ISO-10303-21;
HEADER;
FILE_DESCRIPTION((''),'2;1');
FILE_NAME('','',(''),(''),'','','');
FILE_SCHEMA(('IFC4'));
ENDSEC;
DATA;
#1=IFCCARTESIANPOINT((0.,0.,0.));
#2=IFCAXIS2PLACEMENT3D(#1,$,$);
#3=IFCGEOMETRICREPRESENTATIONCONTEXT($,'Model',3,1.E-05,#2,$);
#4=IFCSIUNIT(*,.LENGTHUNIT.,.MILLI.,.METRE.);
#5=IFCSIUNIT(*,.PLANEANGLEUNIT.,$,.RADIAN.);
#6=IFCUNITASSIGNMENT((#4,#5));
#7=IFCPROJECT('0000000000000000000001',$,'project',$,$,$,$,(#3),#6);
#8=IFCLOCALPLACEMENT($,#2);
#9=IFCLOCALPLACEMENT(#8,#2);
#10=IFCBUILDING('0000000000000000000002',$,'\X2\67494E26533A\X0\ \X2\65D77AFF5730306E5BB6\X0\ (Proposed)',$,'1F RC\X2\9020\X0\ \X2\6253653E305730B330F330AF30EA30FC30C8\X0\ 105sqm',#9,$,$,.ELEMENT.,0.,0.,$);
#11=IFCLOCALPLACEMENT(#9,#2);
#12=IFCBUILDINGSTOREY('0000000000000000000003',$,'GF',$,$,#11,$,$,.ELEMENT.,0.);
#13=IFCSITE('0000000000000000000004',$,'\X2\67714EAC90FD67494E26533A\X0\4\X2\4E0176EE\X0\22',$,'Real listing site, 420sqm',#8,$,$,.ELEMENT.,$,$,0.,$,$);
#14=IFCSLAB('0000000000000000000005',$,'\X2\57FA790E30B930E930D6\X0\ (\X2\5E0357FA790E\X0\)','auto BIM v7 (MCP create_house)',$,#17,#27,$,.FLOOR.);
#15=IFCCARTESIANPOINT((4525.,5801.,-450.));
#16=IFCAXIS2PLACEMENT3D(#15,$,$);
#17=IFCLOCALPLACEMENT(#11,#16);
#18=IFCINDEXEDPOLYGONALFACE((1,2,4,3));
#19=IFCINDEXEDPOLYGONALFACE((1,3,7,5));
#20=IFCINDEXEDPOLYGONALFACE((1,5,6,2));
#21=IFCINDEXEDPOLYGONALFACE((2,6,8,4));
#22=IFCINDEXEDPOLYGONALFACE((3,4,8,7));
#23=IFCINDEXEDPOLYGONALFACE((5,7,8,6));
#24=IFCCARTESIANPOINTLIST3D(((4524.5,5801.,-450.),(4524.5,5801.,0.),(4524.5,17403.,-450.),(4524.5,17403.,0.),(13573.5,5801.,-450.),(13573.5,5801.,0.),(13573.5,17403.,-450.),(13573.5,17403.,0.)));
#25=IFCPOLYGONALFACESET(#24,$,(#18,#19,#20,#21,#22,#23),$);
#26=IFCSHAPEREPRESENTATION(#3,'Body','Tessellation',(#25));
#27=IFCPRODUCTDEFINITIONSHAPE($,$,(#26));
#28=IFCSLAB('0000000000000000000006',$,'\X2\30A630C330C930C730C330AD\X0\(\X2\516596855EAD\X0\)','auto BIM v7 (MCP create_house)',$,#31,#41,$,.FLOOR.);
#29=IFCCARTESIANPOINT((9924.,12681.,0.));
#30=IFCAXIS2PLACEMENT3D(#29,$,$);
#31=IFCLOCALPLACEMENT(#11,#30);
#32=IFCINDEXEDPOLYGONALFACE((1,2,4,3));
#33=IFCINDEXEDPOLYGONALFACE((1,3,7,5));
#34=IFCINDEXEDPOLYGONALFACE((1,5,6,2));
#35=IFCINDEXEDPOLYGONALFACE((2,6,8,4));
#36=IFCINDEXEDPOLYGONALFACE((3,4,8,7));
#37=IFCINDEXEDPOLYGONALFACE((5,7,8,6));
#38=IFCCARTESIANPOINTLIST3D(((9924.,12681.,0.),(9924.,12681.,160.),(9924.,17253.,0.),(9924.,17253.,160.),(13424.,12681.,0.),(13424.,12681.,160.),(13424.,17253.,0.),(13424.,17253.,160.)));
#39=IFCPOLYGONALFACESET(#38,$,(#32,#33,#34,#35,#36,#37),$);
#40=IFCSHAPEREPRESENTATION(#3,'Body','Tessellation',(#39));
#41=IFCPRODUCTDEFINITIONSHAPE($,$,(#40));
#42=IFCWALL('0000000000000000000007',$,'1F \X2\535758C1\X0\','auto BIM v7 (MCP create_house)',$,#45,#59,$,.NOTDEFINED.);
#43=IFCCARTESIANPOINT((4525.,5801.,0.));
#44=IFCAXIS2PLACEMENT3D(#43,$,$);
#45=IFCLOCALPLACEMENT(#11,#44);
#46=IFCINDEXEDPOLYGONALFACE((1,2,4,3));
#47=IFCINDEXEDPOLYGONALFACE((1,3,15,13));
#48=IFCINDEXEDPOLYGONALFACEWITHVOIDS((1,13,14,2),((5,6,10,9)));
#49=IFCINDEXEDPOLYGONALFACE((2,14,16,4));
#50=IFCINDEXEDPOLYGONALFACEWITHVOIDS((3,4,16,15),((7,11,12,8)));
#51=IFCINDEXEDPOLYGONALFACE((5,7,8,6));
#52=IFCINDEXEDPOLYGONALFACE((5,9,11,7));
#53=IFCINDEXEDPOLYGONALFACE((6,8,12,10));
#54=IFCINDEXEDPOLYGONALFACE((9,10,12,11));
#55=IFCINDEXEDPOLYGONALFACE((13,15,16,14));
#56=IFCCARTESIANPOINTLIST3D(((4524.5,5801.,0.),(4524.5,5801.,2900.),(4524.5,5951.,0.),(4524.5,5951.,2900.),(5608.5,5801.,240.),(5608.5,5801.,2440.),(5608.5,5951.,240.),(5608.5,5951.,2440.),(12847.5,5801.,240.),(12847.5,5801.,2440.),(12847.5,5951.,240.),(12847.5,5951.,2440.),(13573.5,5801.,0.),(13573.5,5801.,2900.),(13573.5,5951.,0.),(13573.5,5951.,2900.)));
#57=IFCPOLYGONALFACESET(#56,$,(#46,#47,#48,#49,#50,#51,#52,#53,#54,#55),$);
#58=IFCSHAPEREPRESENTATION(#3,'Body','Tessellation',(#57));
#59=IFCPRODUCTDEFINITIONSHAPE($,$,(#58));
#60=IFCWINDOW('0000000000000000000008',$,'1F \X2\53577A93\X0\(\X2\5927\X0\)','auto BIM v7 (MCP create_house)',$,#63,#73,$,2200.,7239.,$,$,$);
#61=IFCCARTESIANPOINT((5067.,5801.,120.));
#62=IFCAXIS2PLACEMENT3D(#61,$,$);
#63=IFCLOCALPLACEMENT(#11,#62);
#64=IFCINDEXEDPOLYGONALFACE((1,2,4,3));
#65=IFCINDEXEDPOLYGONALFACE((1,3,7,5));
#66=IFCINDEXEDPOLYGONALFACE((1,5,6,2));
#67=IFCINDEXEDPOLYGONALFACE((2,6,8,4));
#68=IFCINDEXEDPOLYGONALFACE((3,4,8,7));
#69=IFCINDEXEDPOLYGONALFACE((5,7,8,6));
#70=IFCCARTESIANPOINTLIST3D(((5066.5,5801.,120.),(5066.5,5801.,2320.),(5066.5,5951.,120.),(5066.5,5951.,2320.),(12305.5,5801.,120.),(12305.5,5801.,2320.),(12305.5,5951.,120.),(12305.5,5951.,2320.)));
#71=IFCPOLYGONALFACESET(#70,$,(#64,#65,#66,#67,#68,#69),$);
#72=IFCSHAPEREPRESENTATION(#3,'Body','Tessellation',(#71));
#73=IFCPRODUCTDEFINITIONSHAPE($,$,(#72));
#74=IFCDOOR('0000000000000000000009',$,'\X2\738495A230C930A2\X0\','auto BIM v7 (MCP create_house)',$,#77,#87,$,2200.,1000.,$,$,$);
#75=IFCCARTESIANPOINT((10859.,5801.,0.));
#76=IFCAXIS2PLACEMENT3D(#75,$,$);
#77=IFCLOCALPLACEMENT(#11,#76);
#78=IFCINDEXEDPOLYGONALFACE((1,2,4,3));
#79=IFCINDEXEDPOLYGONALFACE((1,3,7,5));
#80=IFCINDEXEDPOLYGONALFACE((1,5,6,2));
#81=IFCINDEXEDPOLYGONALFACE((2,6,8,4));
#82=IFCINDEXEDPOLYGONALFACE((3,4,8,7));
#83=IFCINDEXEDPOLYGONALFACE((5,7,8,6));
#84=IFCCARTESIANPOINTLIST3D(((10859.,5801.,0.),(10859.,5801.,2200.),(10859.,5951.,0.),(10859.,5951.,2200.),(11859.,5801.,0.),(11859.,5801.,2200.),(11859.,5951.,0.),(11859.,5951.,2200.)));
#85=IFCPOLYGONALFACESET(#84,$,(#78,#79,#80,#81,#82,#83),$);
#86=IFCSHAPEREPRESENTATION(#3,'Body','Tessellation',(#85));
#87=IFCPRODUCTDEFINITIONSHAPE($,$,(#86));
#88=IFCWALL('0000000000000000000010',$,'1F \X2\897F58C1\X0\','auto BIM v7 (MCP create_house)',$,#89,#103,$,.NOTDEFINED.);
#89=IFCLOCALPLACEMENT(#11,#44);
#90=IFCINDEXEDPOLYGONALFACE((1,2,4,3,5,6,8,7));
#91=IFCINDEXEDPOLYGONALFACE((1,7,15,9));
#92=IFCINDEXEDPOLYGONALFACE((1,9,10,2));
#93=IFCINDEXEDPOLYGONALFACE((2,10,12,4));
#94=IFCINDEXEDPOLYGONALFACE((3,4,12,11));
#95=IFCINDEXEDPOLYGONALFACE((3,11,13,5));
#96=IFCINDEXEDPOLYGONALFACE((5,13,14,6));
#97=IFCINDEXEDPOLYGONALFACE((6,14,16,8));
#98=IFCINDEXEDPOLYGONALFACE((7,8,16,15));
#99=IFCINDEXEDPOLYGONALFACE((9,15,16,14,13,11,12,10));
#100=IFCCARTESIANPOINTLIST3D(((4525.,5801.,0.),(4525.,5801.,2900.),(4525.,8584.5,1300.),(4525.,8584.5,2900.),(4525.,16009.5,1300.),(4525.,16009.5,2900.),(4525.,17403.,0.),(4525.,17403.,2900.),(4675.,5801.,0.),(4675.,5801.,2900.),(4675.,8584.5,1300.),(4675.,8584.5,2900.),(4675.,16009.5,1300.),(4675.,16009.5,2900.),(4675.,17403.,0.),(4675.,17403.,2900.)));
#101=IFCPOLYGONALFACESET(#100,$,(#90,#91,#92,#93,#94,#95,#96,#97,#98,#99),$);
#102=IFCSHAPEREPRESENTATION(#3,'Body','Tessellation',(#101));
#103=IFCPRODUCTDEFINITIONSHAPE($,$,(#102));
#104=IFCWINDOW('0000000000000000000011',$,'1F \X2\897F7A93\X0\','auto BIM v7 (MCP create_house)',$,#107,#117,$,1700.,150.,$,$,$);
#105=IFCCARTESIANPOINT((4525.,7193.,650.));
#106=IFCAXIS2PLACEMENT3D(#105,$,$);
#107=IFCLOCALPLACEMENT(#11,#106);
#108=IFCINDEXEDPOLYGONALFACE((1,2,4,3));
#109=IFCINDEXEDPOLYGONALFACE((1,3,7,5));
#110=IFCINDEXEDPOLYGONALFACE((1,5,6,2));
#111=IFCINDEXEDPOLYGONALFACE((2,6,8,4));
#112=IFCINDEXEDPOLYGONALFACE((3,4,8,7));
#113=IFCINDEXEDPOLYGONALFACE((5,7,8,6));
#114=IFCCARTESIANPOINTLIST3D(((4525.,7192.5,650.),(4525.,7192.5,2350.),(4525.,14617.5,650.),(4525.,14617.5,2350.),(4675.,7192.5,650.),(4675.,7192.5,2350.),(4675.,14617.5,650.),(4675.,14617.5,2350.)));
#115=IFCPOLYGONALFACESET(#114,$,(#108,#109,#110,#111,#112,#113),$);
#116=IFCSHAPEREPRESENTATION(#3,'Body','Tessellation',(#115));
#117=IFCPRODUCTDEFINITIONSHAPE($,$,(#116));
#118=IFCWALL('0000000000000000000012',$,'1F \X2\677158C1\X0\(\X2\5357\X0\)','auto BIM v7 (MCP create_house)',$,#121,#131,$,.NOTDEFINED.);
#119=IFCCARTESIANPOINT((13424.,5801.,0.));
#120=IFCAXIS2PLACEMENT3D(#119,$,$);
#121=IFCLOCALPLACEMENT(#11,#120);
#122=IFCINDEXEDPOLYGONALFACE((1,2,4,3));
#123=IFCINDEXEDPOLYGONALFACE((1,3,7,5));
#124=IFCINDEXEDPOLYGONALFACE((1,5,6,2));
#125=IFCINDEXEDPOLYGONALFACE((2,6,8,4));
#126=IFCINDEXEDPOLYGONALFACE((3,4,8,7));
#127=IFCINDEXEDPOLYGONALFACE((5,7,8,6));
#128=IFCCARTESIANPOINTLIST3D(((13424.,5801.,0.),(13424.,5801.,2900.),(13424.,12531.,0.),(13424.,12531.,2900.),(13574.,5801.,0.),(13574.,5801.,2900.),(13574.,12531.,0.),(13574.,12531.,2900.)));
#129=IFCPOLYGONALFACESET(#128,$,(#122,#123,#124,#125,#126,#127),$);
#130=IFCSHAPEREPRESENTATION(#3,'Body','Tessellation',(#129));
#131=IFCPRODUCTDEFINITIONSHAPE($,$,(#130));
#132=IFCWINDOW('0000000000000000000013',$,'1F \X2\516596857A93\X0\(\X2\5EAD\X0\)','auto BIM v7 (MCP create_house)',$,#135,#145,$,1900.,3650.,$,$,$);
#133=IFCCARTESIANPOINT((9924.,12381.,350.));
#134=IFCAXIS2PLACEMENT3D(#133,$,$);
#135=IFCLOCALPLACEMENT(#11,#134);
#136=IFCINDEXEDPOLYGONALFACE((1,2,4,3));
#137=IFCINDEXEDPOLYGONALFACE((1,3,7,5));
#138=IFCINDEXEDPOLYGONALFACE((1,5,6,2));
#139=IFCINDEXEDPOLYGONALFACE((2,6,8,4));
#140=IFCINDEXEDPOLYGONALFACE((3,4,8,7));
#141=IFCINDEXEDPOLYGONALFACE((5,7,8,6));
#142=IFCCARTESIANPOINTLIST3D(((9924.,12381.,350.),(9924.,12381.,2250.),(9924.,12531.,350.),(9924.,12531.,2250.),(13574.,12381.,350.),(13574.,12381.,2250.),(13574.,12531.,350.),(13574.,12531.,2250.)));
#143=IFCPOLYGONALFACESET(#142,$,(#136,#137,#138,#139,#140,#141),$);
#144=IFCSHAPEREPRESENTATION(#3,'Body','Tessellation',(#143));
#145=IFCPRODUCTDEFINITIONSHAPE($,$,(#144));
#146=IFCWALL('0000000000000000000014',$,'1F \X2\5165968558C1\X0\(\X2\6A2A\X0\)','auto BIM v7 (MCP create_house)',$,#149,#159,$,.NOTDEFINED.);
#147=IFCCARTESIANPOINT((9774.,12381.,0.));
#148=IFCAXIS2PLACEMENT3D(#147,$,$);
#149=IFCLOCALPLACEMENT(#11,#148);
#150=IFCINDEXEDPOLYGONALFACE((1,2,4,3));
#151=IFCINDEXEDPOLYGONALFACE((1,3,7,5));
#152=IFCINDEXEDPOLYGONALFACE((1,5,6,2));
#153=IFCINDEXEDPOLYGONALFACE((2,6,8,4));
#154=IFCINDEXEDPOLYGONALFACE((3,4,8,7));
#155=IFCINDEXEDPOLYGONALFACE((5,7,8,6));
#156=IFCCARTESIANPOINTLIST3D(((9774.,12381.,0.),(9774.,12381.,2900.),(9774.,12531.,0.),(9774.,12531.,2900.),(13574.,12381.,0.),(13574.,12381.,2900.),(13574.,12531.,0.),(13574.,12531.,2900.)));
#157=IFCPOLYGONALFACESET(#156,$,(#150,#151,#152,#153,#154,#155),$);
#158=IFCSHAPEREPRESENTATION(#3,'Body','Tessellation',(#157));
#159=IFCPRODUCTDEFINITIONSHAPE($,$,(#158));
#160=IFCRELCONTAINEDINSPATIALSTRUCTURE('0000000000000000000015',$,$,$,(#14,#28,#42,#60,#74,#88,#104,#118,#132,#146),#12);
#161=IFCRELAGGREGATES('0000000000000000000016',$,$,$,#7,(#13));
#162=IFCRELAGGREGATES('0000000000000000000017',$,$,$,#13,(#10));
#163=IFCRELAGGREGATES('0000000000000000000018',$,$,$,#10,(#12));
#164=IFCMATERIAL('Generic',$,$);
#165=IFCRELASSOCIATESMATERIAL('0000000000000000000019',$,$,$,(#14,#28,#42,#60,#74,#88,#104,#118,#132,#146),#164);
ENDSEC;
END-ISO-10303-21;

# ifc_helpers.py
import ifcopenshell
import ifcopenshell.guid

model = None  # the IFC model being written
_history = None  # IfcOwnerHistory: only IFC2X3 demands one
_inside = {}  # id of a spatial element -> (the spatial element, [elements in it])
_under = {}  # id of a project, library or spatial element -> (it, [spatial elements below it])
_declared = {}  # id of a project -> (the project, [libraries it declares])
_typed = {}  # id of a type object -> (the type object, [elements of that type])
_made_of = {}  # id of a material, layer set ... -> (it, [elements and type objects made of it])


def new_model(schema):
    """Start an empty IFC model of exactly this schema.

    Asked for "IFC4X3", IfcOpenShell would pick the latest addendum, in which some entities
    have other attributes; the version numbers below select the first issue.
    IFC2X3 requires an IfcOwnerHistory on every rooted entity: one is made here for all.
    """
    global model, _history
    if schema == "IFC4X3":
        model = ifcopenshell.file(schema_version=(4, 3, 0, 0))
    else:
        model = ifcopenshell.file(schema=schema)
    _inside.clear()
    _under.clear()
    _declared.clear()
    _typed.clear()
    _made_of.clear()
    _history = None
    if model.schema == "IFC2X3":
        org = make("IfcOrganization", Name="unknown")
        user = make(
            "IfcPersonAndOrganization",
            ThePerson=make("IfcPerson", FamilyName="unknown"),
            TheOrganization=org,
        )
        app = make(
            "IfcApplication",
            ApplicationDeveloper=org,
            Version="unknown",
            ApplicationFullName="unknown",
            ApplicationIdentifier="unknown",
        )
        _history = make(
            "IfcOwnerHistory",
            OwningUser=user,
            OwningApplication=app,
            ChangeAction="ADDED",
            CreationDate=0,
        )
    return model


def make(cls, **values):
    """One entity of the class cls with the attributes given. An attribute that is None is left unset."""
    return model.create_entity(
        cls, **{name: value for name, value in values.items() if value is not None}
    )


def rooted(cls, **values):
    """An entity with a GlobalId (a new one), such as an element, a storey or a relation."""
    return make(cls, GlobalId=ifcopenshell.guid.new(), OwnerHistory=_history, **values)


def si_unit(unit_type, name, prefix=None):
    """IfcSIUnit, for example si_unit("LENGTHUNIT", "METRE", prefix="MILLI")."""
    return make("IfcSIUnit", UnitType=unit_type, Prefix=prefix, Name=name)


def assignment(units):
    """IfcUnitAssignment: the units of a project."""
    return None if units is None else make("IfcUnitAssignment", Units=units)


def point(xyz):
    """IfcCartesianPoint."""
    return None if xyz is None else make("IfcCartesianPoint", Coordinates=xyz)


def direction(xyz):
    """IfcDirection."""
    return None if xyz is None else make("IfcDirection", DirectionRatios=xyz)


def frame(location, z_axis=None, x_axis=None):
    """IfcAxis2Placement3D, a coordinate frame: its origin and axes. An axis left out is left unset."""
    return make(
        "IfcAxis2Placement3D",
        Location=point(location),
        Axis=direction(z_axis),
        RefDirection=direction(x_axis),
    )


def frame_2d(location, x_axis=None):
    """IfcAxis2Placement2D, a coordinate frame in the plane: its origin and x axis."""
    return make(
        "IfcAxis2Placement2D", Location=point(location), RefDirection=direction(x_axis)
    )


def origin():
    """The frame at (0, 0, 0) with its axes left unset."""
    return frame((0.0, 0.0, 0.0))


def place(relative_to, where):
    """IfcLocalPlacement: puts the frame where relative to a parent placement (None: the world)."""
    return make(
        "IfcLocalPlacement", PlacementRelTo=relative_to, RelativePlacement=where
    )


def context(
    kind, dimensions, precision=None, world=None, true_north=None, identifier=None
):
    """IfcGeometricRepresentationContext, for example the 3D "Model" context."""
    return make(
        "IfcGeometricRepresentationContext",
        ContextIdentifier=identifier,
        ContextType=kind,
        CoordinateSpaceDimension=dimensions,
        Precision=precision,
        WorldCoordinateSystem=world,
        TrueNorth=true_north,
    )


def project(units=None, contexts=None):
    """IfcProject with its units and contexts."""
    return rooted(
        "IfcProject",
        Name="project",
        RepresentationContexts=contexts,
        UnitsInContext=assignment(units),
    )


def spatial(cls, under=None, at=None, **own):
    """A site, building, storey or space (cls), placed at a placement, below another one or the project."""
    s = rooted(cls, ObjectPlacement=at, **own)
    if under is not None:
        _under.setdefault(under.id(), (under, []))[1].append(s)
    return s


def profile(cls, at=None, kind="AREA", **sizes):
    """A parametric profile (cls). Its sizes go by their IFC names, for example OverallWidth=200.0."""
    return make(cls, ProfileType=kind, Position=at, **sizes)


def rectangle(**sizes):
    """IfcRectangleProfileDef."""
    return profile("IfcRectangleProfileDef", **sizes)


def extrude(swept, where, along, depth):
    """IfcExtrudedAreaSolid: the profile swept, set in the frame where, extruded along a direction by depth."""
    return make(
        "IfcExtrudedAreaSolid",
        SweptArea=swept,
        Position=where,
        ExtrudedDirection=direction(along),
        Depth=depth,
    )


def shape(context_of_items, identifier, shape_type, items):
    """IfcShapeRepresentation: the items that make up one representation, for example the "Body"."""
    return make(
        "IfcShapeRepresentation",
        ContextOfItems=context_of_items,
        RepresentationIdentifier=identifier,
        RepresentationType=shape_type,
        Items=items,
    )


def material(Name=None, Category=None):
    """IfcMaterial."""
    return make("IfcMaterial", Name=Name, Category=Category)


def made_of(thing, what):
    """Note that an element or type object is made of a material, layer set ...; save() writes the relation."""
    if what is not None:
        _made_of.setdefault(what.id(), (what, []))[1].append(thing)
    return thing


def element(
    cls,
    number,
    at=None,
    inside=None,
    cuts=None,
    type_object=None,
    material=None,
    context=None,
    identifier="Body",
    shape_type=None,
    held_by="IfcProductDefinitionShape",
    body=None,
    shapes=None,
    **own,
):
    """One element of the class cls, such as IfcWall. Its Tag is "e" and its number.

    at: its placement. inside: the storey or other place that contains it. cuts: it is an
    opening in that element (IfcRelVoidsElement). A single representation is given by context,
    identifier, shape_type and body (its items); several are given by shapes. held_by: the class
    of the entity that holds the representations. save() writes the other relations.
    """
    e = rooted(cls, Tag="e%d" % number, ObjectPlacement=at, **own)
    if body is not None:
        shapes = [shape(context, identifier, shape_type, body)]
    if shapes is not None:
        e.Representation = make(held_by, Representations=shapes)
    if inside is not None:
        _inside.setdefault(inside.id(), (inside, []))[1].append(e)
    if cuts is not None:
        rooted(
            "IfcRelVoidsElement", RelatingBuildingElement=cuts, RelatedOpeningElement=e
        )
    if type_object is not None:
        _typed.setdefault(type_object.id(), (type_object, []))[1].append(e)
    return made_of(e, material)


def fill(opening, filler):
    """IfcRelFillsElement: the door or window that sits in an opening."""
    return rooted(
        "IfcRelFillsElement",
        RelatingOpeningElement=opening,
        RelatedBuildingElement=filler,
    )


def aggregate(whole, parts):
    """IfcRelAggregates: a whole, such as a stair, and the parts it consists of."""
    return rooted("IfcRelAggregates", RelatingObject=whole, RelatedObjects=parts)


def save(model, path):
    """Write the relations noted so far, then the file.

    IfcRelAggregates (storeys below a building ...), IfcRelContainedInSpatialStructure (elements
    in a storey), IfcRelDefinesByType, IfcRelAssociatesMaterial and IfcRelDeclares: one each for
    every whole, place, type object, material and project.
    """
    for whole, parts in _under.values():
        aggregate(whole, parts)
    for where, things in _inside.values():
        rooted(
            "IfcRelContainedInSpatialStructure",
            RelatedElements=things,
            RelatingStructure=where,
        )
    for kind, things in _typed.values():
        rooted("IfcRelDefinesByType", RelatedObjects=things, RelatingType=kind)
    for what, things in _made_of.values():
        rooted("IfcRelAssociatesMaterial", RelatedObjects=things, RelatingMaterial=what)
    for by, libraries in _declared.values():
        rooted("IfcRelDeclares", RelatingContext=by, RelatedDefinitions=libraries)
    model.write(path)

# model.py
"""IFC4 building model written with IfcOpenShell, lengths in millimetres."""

from ifc_helpers import new_model, si_unit, frame, frame_2d, origin, place, context, project, spatial, rectangle, extrude, material, element, fill, save


model = new_model("IFC4")

# Units and contexts
model_context = context("Model", 3, precision=1e-05, world=origin())
ifc_project = project(units=[si_unit("LENGTHUNIT", "METRE", prefix="MILLI"), si_unit("PLANEANGLEUNIT", "RADIAN")], contexts=[model_context])

# Site, building, storey
site_placement = place(None, origin())
site = spatial("IfcSite", under=ifc_project, at=site_placement, Name="東京都杉並区4丁目22", ObjectType="Real listing site, 420sqm", CompositionType="ELEMENT", RefElevation=0.0)
building_placement = place(site_placement, origin())
building = spatial("IfcBuilding", under=site, at=building_placement, Name="杉並区 旗竿地の家 (Proposed)", ObjectType="1F RC造 打放しコンクリート 105sqm", CompositionType="ELEMENT", ElevationOfRefHeight=0.0, ElevationOfTerrain=0.0)
storey_placement = place(building_placement, origin())
storey = spatial("IfcBuildingStorey", under=building, at=storey_placement, Name="GF", CompositionType="ELEMENT", Elevation=0.0)

# Slabs
ifc_material = material(Name="Generic")
slab_1_placement = place(storey_placement, frame((4525.0, 5801.0, -450.0)))
element("IfcSlab", 1, at=slab_1_placement, inside=storey, material=ifc_material, Name="基礎スラブ (布基礎)", Description="auto BIM v7 (MCP create_house)", PredefinedType="FLOOR", context=model_context, shape_type="SweptSolid", body=[
    extrude(rectangle(XDim=9049.0, YDim=11602.0, at=frame_2d((4524.0, 5801.0))), frame((4525.0, 5801.0, -450.0)), (0.0, 0.0, 1.0), 450.0),
])
slab_2_placement = place(storey_placement, frame((9924.0, 12681.0, 0.0)))
element("IfcSlab", 2, at=slab_2_placement, inside=storey, material=ifc_material, Name="ウッドデッキ(入隅庭)", Description="auto BIM v7 (MCP create_house)", PredefinedType="FLOOR", context=model_context, shape_type="SweptSolid", body=[
    extrude(rectangle(XDim=3500.0, YDim=4572.0, at=frame_2d((1750.0, 2286.0))), frame((9924.0, 12681.0, 0.0)), (0.0, 0.0, 1.0), 160.0),
])

# Wall, openings, window, door
wall_1_placement = place(storey_placement, frame((4525.0, 5801.0, 0.0)))
wall_1 = element("IfcWall", 3, at=wall_1_placement, inside=storey, material=ifc_material, Name="1F 南壁", Description="auto BIM v7 (MCP create_house)", PredefinedType="NOTDEFINED", context=model_context, shape_type="SweptSolid", body=[
    extrude(rectangle(XDim=9049.0, YDim=150.0, at=frame_2d((4524.0, 75.0))), frame((4525.0, 5801.0, 0.0)), (0.0, 0.0, 1.0), 2900.0),
])
opening_1_placement = place(storey_placement, frame((5067.0, 5801.0, 120.0)))
opening_1 = element("IfcOpeningElement", 4, at=opening_1_placement, cuts=wall_1, PredefinedType="NOTDEFINED", context=model_context, shape_type="SweptSolid", body=[
    extrude(rectangle(XDim=7239.0, YDim=150.0, at=frame_2d((3619.0, 75.0))), frame((5067.0, 5801.0, 120.0)), (0.0, 0.0, 1.0), 2200.0),
])
opening_2_placement = place(storey_placement, frame((10859.0, 5801.0, 0.0)))
opening_2 = element("IfcOpeningElement", 5, at=opening_2_placement, cuts=wall_1, PredefinedType="NOTDEFINED", context=model_context, shape_type="SweptSolid", body=[
    extrude(rectangle(XDim=1000.0, YDim=150.0, at=frame_2d((500.0, 75.0))), frame((10859.0, 5801.0, 0.0)), (0.0, 0.0, 1.0), 2200.0),
])
window_1_placement = place(storey_placement, frame((5067.0, 5801.0, 120.0)))
window_1 = element("IfcWindow", 6, at=window_1_placement, inside=storey, material=ifc_material, Name="1F 南窓(大)", Description="auto BIM v7 (MCP create_house)", OverallHeight=2200.0, OverallWidth=7239.0, context=model_context, shape_type="SweptSolid", body=[
    extrude(rectangle(XDim=7239.0, YDim=150.0, at=frame_2d((3619.0, 75.0))), frame((5067.0, 5801.0, 120.0)), (0.0, 0.0, 1.0), 2200.0),
])
fill(opening_1, window_1)
door_placement = place(storey_placement, frame((10859.0, 5801.0, 0.0)))
door = element("IfcDoor", 7, at=door_placement, inside=storey, material=ifc_material, Name="玄関ドア", Description="auto BIM v7 (MCP create_house)", OverallHeight=2200.0, OverallWidth=1000.0, context=model_context, shape_type="SweptSolid", body=[
    extrude(rectangle(XDim=1000.0, YDim=150.0, at=frame_2d((500.0, 75.0))), frame((10859.0, 5801.0, 0.0)), (0.0, 0.0, 1.0), 2200.0),
])
fill(opening_2, door)

# Wall, opening, window
wall_2_placement = place(storey_placement, frame((4525.0, 5801.0, 0.0)))
wall_2 = element("IfcWall", 8, at=wall_2_placement, inside=storey, material=ifc_material, Name="1F 西壁", Description="auto BIM v7 (MCP create_house)", PredefinedType="NOTDEFINED", context=model_context, shape_type="SweptSolid", body=[
    extrude(rectangle(XDim=150.0, YDim=11602.0, at=frame_2d((75.0, 5801.0))), frame((4525.0, 5801.0, 0.0)), (0.0, 0.0, 1.0), 2900.0),
])
opening_3_placement = place(storey_placement, frame((4525.0, 7193.0, 650.0)))
opening_3 = element("IfcOpeningElement", 9, at=opening_3_placement, cuts=wall_2, PredefinedType="NOTDEFINED", context=model_context, shape_type="SweptSolid", body=[
    extrude(rectangle(XDim=150.0, YDim=7425.0, at=frame_2d((75.0, 3712.0))), frame((4525.0, 7193.0, 650.0)), (0.0, 0.0, 1.0), 1700.0),
])
window_2_placement = place(storey_placement, frame((4525.0, 7193.0, 650.0)))
window_2 = element("IfcWindow", 10, at=window_2_placement, inside=storey, material=ifc_material, Name="1F 西窓", Description="auto BIM v7 (MCP create_house)", OverallHeight=1700.0, OverallWidth=150.0, context=model_context, shape_type="SweptSolid", body=[
    extrude(rectangle(XDim=150.0, YDim=7425.0, at=frame_2d((75.0, 3712.0))), frame((4525.0, 7193.0, 650.0)), (0.0, 0.0, 1.0), 1700.0),
])
fill(opening_3, window_2)

# Wall, opening, window
wall_3_placement = place(storey_placement, frame((13424.0, 5801.0, 0.0)))
wall_3 = element("IfcWall", 11, at=wall_3_placement, inside=storey, material=ifc_material, Name="1F 東壁(南)", Description="auto BIM v7 (MCP create_house)", PredefinedType="NOTDEFINED", context=model_context, shape_type="SweptSolid", body=[
    extrude(rectangle(XDim=150.0, YDim=6730.0, at=frame_2d((75.0, 3365.0))), frame((13424.0, 5801.0, 0.0)), (0.0, 0.0, 1.0), 2900.0),
])
opening_4_placement = place(storey_placement, frame((9924.0, 12381.0, 350.0)))
opening_4 = element("IfcOpeningElement", 12, at=opening_4_placement, cuts=wall_3, PredefinedType="NOTDEFINED", context=model_context, shape_type="SweptSolid", body=[
    extrude(rectangle(XDim=3650.0, YDim=150.0, at=frame_2d((1825.0, 75.0))), frame((9924.0, 12381.0, 350.0)), (0.0, 0.0, 1.0), 1900.0),
])
window_3_placement = place(storey_placement, frame((9924.0, 12381.0, 350.0)))
window_3 = element("IfcWindow", 13, at=window_3_placement, inside=storey, material=ifc_material, Name="1F 入隅窓(庭)", Description="auto BIM v7 (MCP create_house)", OverallHeight=1900.0, OverallWidth=3650.0, context=model_context, shape_type="SweptSolid", body=[
    extrude(rectangle(XDim=3650.0, YDim=150.0, at=frame_2d((1825.0, 75.0))), frame((9924.0, 12381.0, 350.0)), (0.0, 0.0, 1.0), 1900.0),
])
fill(opening_4, window_3)

# Wall
wall_4_placement = place(storey_placement, frame((9774.0, 12381.0, 0.0)))
element("IfcWall", 14, at=wall_4_placement, inside=storey, material=ifc_material, Name="1F 入隅壁(横)", Description="auto BIM v7 (MCP create_house)", PredefinedType="NOTDEFINED", context=model_context, shape_type="SweptSolid", body=[
    extrude(rectangle(XDim=3800.0, YDim=150.0, at=frame_2d((1900.0, 75.0))), frame((9774.0, 12381.0, 0.0)), (0.0, 0.0, 1.0), 2900.0),
])

save(model, "model.ifc")
